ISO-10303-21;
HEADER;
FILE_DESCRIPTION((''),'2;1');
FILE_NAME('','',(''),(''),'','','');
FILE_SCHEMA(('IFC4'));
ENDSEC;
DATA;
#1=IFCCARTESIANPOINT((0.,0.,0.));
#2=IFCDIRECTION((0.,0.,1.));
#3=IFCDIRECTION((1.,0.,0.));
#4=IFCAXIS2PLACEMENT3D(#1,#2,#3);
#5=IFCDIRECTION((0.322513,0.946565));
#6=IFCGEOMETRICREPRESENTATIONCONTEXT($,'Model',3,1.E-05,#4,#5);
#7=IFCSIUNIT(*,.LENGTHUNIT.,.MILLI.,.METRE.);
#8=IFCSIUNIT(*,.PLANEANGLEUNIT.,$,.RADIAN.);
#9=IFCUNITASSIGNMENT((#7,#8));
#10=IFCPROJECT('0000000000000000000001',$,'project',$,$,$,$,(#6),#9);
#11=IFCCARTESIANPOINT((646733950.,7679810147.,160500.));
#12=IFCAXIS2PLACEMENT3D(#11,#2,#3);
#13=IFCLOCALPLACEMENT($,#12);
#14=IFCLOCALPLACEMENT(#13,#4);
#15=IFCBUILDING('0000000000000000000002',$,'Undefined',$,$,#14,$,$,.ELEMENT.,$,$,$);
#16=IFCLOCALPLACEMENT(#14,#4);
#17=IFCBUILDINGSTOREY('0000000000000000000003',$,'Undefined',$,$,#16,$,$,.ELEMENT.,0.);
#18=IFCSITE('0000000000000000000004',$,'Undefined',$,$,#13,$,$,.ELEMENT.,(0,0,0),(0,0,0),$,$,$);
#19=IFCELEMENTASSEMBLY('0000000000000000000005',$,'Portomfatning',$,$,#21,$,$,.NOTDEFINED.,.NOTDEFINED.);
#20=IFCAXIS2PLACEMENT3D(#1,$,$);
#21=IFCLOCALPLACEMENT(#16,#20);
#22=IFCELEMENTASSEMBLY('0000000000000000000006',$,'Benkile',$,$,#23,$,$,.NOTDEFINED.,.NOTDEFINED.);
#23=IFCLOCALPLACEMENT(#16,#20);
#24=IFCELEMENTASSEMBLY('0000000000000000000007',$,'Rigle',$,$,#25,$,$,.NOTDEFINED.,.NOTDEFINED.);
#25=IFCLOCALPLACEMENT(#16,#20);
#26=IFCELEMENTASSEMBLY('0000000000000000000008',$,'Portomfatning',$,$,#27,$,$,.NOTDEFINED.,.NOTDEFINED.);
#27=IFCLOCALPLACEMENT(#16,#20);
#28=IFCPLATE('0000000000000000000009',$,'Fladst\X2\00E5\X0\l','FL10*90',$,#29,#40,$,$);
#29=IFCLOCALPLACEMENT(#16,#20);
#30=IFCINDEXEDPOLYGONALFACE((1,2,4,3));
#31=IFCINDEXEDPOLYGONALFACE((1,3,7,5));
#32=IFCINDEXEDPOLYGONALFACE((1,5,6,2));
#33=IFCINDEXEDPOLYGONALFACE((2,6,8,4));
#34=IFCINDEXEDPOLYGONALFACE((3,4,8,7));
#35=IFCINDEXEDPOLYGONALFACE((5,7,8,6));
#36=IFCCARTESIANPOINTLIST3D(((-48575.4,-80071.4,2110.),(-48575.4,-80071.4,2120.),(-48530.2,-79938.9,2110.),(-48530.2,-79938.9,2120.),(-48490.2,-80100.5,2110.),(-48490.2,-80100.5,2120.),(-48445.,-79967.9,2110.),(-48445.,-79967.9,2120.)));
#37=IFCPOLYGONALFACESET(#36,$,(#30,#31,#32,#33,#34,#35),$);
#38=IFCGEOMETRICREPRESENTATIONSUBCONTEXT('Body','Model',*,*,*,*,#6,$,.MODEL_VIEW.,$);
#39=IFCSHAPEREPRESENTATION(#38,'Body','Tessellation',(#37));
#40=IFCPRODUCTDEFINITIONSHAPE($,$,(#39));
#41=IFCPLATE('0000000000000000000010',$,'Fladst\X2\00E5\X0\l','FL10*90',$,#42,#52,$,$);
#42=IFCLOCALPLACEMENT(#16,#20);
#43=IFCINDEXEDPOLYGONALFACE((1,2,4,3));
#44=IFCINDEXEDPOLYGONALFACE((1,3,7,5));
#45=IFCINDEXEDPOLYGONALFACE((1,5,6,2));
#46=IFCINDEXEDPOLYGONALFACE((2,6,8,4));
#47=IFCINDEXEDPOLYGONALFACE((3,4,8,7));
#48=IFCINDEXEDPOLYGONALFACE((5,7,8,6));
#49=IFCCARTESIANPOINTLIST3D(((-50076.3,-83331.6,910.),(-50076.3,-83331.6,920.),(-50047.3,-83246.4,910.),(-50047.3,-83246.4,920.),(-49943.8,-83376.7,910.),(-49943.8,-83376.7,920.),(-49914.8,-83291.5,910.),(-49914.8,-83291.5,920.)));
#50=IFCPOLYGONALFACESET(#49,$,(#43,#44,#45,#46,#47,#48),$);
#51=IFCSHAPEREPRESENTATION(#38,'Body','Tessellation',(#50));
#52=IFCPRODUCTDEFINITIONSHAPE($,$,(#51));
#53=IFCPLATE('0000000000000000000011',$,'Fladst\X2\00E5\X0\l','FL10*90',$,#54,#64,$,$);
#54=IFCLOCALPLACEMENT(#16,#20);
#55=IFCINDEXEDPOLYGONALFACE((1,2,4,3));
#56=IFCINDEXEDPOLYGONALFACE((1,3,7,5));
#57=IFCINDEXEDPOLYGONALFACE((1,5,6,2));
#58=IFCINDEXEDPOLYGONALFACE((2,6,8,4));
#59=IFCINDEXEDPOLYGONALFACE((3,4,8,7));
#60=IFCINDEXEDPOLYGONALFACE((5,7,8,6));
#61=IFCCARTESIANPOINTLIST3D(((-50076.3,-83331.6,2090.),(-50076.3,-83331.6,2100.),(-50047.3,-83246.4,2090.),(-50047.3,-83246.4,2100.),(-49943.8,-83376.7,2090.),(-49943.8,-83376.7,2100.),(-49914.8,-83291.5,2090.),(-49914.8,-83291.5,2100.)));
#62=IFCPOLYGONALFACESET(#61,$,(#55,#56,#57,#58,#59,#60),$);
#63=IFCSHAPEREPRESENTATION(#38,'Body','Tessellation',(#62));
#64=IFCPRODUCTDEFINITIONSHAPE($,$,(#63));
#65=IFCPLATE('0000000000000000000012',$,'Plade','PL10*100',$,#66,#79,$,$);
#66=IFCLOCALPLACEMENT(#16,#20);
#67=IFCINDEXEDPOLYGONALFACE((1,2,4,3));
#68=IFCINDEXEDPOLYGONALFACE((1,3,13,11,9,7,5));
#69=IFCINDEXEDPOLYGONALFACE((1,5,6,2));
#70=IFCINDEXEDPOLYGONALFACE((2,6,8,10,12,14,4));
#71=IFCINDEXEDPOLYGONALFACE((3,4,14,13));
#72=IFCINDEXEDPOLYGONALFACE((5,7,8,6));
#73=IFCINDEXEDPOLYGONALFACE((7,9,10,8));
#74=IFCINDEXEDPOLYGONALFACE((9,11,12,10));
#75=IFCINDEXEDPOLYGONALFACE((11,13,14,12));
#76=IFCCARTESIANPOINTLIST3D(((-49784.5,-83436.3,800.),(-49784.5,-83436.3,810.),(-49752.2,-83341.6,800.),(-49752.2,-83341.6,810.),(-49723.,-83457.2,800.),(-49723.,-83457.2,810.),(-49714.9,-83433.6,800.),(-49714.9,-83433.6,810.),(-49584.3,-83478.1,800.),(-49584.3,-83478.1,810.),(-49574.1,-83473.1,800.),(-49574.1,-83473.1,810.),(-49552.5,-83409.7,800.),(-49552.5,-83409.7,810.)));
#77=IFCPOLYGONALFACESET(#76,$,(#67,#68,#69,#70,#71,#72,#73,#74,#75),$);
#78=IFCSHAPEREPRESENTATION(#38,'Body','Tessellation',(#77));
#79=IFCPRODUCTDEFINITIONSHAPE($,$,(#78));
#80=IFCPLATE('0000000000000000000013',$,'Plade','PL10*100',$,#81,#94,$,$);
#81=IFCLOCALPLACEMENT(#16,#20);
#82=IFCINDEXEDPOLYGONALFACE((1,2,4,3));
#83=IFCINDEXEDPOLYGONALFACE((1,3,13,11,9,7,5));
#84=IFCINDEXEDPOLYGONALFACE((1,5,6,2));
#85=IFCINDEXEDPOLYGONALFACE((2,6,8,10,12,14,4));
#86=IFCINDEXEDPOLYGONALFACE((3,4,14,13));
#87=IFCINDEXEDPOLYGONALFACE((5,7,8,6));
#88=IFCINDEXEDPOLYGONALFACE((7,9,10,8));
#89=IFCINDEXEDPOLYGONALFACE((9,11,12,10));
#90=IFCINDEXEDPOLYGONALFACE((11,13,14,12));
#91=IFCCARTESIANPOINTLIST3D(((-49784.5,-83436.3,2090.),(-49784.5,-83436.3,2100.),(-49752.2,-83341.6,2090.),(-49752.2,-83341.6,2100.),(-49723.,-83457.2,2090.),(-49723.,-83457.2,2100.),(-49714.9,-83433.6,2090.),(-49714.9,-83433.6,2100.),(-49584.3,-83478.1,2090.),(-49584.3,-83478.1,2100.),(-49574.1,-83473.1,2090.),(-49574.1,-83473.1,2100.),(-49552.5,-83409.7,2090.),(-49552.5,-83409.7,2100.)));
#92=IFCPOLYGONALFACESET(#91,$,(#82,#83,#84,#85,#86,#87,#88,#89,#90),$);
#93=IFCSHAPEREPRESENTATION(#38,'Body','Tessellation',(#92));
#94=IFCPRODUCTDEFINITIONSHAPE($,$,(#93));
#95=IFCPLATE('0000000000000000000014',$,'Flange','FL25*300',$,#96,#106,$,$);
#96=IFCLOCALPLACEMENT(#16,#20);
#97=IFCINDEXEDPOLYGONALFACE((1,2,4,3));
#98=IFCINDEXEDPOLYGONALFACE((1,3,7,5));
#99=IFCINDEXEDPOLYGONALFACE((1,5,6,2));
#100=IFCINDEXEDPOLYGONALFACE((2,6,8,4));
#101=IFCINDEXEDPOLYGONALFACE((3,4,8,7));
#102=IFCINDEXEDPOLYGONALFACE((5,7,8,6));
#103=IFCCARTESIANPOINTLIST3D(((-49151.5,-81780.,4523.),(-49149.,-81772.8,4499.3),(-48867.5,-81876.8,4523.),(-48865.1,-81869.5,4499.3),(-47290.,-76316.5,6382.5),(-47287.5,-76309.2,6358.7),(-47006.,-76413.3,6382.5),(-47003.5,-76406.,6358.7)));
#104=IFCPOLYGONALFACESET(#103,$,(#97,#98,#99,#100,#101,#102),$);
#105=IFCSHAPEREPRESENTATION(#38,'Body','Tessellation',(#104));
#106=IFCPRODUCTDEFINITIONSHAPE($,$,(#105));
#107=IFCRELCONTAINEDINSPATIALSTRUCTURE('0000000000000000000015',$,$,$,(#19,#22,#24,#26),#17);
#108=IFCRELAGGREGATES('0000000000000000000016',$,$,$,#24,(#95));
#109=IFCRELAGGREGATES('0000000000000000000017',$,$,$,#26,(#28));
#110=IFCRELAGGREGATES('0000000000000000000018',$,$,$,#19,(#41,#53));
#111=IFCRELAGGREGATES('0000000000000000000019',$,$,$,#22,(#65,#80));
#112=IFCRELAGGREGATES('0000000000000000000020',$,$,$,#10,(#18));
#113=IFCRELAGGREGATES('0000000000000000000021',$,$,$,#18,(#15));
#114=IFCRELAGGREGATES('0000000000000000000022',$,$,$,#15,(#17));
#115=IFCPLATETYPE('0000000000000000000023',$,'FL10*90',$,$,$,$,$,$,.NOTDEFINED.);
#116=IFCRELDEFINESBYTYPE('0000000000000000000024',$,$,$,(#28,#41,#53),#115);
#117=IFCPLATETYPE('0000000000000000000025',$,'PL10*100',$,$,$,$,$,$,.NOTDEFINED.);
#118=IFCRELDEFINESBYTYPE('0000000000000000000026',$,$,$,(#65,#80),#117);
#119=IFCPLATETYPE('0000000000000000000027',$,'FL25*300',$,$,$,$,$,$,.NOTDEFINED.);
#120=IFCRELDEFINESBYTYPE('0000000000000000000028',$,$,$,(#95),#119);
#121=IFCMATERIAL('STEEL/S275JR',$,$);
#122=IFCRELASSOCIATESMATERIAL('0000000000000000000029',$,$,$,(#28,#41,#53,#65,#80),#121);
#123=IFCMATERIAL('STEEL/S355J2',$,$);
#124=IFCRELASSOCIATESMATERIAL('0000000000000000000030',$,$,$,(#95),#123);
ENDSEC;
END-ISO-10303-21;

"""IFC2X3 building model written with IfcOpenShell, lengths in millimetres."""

from ifc_helpers import new_model, si_unit, direction, frame, origin_with_axes, place, context, subcontext, project, spatial, polyline, outline, extrude, boolean, clip, halfspace, material, type_object, element, aggregate, save


model = new_model("IFC2X3")

# Units and contexts
model_context = context("Model", 3, precision=1e-05, world=origin_with_axes(), true_north=direction((0.322513, 0.946565)))
body_context = subcontext(model_context, "Body", "Model", "MODEL_VIEW")
ifc_project = project(units=[si_unit("LENGTHUNIT", "METRE", prefix="MILLI"), si_unit("PLANEANGLEUNIT", "RADIAN")], contexts=[model_context])

# Site, building, storey
site_placement = place(None, frame((646733950.0, 7679810147.0, 160500.0), z_axis=(0.0, 0.0, 1.0), x_axis=(1.0, 0.0, 0.0)))
site = spatial("IfcSite", under=ifc_project, at=site_placement, Name="Undefined", CompositionType="ELEMENT", RefLatitude=(0, 0, 0), RefLongitude=(0, 0, 0))
building_placement = place(site_placement, origin_with_axes())
building = spatial("IfcBuilding", under=site, at=building_placement, Name="Undefined", CompositionType="ELEMENT")
storey_placement = place(building_placement, origin_with_axes())
storey = spatial("IfcBuildingStorey", under=building, at=storey_placement, Name="Undefined", CompositionType="ELEMENT", Elevation=0.0)

# Element assembly
assembly_1_placement = place(storey_placement, origin_with_axes())
assembly_1 = element("IfcElementAssembly", 1, at=assembly_1_placement, inside=storey, Name="Portomfatning", AssemblyPlace="NOTDEFINED", PredefinedType="NOTDEFINED")

# Shared definitions
ifc_material_1 = material(Name="STEEL/S355J2")

# Element assembly
assembly_2_placement = place(storey_placement, origin_with_axes())
assembly_2 = element("IfcElementAssembly", 2, at=assembly_2_placement, inside=storey, Name="Benkile", AssemblyPlace="NOTDEFINED", PredefinedType="NOTDEFINED")
ifc_material_2 = material(Name="STEEL/S275JR")

# Element assembly
assembly_3_placement = place(storey_placement, origin_with_axes())
assembly_3 = element("IfcElementAssembly", 3, at=assembly_3_placement, inside=storey, Name="Rigle", AssemblyPlace="NOTDEFINED", PredefinedType="NOTDEFINED")

# Shared definitions
plate_type_1 = type_object("IfcPlateType", Name="FL10*90", PredefinedType="NOTDEFINED")

# Element assembly, plate
assembly_4_placement = place(storey_placement, origin_with_axes())
assembly_4 = element("IfcElementAssembly", 4, at=assembly_4_placement, inside=storey, Name="Portomfatning", AssemblyPlace="NOTDEFINED", PredefinedType="NOTDEFINED")
plate_1_placement = place(assembly_4_placement, frame((-48532.8, -80085.9, 2115.0), z_axis=(0.0, 0.0, -1.0), x_axis=(0.322513, 0.946565, 0.0)))
plate_1 = element("IfcPlate", 5, at=plate_1_placement, type_object=plate_type_1, material=ifc_material_2, Name="Fladstål", Description="FL10*90", context=body_context, shape_type="SweptSolid", body=[
    extrude(outline(polyline([(0.0, -45.0), (0.0, 45.0), (140.0, 45.0), (140.0, -45.0), (0.0, -45.0)])), frame((0.0, 0.0, -5.0), z_axis=(0.0, 0.0, 1.0), x_axis=(1.0, 0.0, 0.0)), (0.0, 0.0, 1.0), 10.0),
])

# Plates
plate_2_placement = place(assembly_1_placement, frame((-50061.8, -83289.0, 915.0), z_axis=(0.0, 0.0, 1.0), x_axis=(0.946565, -0.322513, 0.0)))
plate_2 = element("IfcPlate", 6, at=plate_2_placement, type_object=plate_type_1, material=ifc_material_2, Name="Fladstål", Description="FL10*90", context=body_context, shape_type="SweptSolid", body=[
    extrude(outline(polyline([(0.0, -45.0), (0.0, 45.0), (140.0, 45.0), (140.0, -45.0), (0.0, -45.0)])), frame((0.0, 0.0, -5.0), z_axis=(0.0, 0.0, 1.0), x_axis=(1.0, 0.0, 0.0)), (0.0, 0.0, 1.0), 10.0),
])
plate_3_placement = place(assembly_1_placement, frame((-50061.8, -83289.0, 2095.0), z_axis=(0.0, 0.0, -1.0), x_axis=(0.946565, -0.322513, 0.0)))
plate_3 = element("IfcPlate", 7, at=plate_3_placement, type_object=plate_type_1, material=ifc_material_2, Name="Fladstål", Description="FL10*90", context=body_context, shape_type="SweptSolid", body=[
    extrude(outline(polyline([(0.0, -45.0), (0.0, 45.0), (140.0, 45.0), (140.0, -45.0), (0.0, -45.0)])), frame((0.0, 0.0, -5.0), z_axis=(0.0, 0.0, 1.0), x_axis=(1.0, 0.0, 0.0)), (0.0, 0.0, 1.0), 10.0),
])
plate_type_2 = type_object("IfcPlateType", Name="PL10*100", PredefinedType="NOTDEFINED")
plate_4_placement = place(assembly_2_placement, frame((-49552.5, -83409.7, 805.0), z_axis=(0.0, 0.0, 1.0), x_axis=(-0.946565, 0.322513, 0.0)))
plate_4 = element("IfcPlate", 8, at=plate_4_placement, type_object=plate_type_2, material=ifc_material_2, Name="Plade", Description="PL10*100", context=body_context, shape_type="CSG", body=[
    boolean("DIFFERENCE", extrude(outline(polyline([(0.0, 0.0), (211.0, 0.0), (211.0, 100.0), (146.0, 100.0), (146.0, 75.0), (0.0, 75.0), (0.0, 0.0)])), frame((0.0, 0.0, -5.0), z_axis=(0.0, 0.0, 1.0), x_axis=(1.0, 0.0, 0.0)), (0.0, 0.0, 1.0), 10.0), extrude(outline(polyline([(0.0, 0.0), (8.0, 0.0), (0.0, 8.0), (0.0, 0.0)])), frame((0.0, 75.0, 7.5), z_axis=(0.0, 0.0, -1.0), x_axis=(1.0, 0.0, 0.0)), (0.0, 0.0, 1.0), 15.0)),
])
plate_5_placement = place(assembly_2_placement, frame((-49552.5, -83409.7, 2095.0), z_axis=(0.0, 0.0, 1.0), x_axis=(-0.946565, 0.322513, 0.0)))
plate_5 = element("IfcPlate", 9, at=plate_5_placement, type_object=plate_type_2, material=ifc_material_2, Name="Plade", Description="PL10*100", context=body_context, shape_type="CSG", body=[
    boolean("DIFFERENCE", extrude(outline(polyline([(0.0, 0.0), (211.0, 0.0), (211.0, 100.0), (146.0, 100.0), (146.0, 75.0), (0.0, 75.0), (0.0, 0.0)])), frame((0.0, 0.0, -5.0), z_axis=(0.0, 0.0, 1.0), x_axis=(1.0, 0.0, 0.0)), (0.0, 0.0, 1.0), 10.0), extrude(outline(polyline([(0.0, 0.0), (8.0, 0.0), (0.0, 8.0), (0.0, 0.0)])), frame((0.0, 75.0, 7.5), z_axis=(0.0, 0.0, -1.0), x_axis=(1.0, 0.0, 0.0)), (0.0, 0.0, 1.0), 15.0)),
])
plate_type_3 = type_object("IfcPlateType", Name="FL25*300", PredefinedType="NOTDEFINED")
plate_6_placement = place(assembly_3_placement, frame((-49008.3, -81824.8, 4511.2), z_axis=(0.098895, 0.290253, -0.951826), x_axis=(0.306976, 0.900965, 0.306638)))
plate_6 = element("IfcPlate", 10, at=plate_6_placement, type_object=plate_type_3, material=ifc_material_1, Name="Flange", Description="FL25*300", context=body_context, shape_type="Clipping", body=[
    clip(extrude(outline(polyline([(0.0, -150.0), (0.0, 150.0), (6064.1, 150.0), (6064.1, -150.0), (0.0, -150.0)])), frame((0.0, 0.0, -12.5), z_axis=(0.0, 0.0, 1.0), x_axis=(1.0, 0.0, 0.0)), (0.0, 0.0, 1.0), 25.0), halfspace(frame((6064.1, 0.0, 0.3), z_axis=(1.0, 0.0, 0.0), x_axis=(0.0, 1.0, 0.0)), False)),
])
aggregate(assembly_3, [plate_6])

aggregate(assembly_4, [plate_1])
aggregate(assembly_1, [plate_2, plate_3])
aggregate(assembly_2, [plate_4, plate_5])

save(model, "model.ifc")
